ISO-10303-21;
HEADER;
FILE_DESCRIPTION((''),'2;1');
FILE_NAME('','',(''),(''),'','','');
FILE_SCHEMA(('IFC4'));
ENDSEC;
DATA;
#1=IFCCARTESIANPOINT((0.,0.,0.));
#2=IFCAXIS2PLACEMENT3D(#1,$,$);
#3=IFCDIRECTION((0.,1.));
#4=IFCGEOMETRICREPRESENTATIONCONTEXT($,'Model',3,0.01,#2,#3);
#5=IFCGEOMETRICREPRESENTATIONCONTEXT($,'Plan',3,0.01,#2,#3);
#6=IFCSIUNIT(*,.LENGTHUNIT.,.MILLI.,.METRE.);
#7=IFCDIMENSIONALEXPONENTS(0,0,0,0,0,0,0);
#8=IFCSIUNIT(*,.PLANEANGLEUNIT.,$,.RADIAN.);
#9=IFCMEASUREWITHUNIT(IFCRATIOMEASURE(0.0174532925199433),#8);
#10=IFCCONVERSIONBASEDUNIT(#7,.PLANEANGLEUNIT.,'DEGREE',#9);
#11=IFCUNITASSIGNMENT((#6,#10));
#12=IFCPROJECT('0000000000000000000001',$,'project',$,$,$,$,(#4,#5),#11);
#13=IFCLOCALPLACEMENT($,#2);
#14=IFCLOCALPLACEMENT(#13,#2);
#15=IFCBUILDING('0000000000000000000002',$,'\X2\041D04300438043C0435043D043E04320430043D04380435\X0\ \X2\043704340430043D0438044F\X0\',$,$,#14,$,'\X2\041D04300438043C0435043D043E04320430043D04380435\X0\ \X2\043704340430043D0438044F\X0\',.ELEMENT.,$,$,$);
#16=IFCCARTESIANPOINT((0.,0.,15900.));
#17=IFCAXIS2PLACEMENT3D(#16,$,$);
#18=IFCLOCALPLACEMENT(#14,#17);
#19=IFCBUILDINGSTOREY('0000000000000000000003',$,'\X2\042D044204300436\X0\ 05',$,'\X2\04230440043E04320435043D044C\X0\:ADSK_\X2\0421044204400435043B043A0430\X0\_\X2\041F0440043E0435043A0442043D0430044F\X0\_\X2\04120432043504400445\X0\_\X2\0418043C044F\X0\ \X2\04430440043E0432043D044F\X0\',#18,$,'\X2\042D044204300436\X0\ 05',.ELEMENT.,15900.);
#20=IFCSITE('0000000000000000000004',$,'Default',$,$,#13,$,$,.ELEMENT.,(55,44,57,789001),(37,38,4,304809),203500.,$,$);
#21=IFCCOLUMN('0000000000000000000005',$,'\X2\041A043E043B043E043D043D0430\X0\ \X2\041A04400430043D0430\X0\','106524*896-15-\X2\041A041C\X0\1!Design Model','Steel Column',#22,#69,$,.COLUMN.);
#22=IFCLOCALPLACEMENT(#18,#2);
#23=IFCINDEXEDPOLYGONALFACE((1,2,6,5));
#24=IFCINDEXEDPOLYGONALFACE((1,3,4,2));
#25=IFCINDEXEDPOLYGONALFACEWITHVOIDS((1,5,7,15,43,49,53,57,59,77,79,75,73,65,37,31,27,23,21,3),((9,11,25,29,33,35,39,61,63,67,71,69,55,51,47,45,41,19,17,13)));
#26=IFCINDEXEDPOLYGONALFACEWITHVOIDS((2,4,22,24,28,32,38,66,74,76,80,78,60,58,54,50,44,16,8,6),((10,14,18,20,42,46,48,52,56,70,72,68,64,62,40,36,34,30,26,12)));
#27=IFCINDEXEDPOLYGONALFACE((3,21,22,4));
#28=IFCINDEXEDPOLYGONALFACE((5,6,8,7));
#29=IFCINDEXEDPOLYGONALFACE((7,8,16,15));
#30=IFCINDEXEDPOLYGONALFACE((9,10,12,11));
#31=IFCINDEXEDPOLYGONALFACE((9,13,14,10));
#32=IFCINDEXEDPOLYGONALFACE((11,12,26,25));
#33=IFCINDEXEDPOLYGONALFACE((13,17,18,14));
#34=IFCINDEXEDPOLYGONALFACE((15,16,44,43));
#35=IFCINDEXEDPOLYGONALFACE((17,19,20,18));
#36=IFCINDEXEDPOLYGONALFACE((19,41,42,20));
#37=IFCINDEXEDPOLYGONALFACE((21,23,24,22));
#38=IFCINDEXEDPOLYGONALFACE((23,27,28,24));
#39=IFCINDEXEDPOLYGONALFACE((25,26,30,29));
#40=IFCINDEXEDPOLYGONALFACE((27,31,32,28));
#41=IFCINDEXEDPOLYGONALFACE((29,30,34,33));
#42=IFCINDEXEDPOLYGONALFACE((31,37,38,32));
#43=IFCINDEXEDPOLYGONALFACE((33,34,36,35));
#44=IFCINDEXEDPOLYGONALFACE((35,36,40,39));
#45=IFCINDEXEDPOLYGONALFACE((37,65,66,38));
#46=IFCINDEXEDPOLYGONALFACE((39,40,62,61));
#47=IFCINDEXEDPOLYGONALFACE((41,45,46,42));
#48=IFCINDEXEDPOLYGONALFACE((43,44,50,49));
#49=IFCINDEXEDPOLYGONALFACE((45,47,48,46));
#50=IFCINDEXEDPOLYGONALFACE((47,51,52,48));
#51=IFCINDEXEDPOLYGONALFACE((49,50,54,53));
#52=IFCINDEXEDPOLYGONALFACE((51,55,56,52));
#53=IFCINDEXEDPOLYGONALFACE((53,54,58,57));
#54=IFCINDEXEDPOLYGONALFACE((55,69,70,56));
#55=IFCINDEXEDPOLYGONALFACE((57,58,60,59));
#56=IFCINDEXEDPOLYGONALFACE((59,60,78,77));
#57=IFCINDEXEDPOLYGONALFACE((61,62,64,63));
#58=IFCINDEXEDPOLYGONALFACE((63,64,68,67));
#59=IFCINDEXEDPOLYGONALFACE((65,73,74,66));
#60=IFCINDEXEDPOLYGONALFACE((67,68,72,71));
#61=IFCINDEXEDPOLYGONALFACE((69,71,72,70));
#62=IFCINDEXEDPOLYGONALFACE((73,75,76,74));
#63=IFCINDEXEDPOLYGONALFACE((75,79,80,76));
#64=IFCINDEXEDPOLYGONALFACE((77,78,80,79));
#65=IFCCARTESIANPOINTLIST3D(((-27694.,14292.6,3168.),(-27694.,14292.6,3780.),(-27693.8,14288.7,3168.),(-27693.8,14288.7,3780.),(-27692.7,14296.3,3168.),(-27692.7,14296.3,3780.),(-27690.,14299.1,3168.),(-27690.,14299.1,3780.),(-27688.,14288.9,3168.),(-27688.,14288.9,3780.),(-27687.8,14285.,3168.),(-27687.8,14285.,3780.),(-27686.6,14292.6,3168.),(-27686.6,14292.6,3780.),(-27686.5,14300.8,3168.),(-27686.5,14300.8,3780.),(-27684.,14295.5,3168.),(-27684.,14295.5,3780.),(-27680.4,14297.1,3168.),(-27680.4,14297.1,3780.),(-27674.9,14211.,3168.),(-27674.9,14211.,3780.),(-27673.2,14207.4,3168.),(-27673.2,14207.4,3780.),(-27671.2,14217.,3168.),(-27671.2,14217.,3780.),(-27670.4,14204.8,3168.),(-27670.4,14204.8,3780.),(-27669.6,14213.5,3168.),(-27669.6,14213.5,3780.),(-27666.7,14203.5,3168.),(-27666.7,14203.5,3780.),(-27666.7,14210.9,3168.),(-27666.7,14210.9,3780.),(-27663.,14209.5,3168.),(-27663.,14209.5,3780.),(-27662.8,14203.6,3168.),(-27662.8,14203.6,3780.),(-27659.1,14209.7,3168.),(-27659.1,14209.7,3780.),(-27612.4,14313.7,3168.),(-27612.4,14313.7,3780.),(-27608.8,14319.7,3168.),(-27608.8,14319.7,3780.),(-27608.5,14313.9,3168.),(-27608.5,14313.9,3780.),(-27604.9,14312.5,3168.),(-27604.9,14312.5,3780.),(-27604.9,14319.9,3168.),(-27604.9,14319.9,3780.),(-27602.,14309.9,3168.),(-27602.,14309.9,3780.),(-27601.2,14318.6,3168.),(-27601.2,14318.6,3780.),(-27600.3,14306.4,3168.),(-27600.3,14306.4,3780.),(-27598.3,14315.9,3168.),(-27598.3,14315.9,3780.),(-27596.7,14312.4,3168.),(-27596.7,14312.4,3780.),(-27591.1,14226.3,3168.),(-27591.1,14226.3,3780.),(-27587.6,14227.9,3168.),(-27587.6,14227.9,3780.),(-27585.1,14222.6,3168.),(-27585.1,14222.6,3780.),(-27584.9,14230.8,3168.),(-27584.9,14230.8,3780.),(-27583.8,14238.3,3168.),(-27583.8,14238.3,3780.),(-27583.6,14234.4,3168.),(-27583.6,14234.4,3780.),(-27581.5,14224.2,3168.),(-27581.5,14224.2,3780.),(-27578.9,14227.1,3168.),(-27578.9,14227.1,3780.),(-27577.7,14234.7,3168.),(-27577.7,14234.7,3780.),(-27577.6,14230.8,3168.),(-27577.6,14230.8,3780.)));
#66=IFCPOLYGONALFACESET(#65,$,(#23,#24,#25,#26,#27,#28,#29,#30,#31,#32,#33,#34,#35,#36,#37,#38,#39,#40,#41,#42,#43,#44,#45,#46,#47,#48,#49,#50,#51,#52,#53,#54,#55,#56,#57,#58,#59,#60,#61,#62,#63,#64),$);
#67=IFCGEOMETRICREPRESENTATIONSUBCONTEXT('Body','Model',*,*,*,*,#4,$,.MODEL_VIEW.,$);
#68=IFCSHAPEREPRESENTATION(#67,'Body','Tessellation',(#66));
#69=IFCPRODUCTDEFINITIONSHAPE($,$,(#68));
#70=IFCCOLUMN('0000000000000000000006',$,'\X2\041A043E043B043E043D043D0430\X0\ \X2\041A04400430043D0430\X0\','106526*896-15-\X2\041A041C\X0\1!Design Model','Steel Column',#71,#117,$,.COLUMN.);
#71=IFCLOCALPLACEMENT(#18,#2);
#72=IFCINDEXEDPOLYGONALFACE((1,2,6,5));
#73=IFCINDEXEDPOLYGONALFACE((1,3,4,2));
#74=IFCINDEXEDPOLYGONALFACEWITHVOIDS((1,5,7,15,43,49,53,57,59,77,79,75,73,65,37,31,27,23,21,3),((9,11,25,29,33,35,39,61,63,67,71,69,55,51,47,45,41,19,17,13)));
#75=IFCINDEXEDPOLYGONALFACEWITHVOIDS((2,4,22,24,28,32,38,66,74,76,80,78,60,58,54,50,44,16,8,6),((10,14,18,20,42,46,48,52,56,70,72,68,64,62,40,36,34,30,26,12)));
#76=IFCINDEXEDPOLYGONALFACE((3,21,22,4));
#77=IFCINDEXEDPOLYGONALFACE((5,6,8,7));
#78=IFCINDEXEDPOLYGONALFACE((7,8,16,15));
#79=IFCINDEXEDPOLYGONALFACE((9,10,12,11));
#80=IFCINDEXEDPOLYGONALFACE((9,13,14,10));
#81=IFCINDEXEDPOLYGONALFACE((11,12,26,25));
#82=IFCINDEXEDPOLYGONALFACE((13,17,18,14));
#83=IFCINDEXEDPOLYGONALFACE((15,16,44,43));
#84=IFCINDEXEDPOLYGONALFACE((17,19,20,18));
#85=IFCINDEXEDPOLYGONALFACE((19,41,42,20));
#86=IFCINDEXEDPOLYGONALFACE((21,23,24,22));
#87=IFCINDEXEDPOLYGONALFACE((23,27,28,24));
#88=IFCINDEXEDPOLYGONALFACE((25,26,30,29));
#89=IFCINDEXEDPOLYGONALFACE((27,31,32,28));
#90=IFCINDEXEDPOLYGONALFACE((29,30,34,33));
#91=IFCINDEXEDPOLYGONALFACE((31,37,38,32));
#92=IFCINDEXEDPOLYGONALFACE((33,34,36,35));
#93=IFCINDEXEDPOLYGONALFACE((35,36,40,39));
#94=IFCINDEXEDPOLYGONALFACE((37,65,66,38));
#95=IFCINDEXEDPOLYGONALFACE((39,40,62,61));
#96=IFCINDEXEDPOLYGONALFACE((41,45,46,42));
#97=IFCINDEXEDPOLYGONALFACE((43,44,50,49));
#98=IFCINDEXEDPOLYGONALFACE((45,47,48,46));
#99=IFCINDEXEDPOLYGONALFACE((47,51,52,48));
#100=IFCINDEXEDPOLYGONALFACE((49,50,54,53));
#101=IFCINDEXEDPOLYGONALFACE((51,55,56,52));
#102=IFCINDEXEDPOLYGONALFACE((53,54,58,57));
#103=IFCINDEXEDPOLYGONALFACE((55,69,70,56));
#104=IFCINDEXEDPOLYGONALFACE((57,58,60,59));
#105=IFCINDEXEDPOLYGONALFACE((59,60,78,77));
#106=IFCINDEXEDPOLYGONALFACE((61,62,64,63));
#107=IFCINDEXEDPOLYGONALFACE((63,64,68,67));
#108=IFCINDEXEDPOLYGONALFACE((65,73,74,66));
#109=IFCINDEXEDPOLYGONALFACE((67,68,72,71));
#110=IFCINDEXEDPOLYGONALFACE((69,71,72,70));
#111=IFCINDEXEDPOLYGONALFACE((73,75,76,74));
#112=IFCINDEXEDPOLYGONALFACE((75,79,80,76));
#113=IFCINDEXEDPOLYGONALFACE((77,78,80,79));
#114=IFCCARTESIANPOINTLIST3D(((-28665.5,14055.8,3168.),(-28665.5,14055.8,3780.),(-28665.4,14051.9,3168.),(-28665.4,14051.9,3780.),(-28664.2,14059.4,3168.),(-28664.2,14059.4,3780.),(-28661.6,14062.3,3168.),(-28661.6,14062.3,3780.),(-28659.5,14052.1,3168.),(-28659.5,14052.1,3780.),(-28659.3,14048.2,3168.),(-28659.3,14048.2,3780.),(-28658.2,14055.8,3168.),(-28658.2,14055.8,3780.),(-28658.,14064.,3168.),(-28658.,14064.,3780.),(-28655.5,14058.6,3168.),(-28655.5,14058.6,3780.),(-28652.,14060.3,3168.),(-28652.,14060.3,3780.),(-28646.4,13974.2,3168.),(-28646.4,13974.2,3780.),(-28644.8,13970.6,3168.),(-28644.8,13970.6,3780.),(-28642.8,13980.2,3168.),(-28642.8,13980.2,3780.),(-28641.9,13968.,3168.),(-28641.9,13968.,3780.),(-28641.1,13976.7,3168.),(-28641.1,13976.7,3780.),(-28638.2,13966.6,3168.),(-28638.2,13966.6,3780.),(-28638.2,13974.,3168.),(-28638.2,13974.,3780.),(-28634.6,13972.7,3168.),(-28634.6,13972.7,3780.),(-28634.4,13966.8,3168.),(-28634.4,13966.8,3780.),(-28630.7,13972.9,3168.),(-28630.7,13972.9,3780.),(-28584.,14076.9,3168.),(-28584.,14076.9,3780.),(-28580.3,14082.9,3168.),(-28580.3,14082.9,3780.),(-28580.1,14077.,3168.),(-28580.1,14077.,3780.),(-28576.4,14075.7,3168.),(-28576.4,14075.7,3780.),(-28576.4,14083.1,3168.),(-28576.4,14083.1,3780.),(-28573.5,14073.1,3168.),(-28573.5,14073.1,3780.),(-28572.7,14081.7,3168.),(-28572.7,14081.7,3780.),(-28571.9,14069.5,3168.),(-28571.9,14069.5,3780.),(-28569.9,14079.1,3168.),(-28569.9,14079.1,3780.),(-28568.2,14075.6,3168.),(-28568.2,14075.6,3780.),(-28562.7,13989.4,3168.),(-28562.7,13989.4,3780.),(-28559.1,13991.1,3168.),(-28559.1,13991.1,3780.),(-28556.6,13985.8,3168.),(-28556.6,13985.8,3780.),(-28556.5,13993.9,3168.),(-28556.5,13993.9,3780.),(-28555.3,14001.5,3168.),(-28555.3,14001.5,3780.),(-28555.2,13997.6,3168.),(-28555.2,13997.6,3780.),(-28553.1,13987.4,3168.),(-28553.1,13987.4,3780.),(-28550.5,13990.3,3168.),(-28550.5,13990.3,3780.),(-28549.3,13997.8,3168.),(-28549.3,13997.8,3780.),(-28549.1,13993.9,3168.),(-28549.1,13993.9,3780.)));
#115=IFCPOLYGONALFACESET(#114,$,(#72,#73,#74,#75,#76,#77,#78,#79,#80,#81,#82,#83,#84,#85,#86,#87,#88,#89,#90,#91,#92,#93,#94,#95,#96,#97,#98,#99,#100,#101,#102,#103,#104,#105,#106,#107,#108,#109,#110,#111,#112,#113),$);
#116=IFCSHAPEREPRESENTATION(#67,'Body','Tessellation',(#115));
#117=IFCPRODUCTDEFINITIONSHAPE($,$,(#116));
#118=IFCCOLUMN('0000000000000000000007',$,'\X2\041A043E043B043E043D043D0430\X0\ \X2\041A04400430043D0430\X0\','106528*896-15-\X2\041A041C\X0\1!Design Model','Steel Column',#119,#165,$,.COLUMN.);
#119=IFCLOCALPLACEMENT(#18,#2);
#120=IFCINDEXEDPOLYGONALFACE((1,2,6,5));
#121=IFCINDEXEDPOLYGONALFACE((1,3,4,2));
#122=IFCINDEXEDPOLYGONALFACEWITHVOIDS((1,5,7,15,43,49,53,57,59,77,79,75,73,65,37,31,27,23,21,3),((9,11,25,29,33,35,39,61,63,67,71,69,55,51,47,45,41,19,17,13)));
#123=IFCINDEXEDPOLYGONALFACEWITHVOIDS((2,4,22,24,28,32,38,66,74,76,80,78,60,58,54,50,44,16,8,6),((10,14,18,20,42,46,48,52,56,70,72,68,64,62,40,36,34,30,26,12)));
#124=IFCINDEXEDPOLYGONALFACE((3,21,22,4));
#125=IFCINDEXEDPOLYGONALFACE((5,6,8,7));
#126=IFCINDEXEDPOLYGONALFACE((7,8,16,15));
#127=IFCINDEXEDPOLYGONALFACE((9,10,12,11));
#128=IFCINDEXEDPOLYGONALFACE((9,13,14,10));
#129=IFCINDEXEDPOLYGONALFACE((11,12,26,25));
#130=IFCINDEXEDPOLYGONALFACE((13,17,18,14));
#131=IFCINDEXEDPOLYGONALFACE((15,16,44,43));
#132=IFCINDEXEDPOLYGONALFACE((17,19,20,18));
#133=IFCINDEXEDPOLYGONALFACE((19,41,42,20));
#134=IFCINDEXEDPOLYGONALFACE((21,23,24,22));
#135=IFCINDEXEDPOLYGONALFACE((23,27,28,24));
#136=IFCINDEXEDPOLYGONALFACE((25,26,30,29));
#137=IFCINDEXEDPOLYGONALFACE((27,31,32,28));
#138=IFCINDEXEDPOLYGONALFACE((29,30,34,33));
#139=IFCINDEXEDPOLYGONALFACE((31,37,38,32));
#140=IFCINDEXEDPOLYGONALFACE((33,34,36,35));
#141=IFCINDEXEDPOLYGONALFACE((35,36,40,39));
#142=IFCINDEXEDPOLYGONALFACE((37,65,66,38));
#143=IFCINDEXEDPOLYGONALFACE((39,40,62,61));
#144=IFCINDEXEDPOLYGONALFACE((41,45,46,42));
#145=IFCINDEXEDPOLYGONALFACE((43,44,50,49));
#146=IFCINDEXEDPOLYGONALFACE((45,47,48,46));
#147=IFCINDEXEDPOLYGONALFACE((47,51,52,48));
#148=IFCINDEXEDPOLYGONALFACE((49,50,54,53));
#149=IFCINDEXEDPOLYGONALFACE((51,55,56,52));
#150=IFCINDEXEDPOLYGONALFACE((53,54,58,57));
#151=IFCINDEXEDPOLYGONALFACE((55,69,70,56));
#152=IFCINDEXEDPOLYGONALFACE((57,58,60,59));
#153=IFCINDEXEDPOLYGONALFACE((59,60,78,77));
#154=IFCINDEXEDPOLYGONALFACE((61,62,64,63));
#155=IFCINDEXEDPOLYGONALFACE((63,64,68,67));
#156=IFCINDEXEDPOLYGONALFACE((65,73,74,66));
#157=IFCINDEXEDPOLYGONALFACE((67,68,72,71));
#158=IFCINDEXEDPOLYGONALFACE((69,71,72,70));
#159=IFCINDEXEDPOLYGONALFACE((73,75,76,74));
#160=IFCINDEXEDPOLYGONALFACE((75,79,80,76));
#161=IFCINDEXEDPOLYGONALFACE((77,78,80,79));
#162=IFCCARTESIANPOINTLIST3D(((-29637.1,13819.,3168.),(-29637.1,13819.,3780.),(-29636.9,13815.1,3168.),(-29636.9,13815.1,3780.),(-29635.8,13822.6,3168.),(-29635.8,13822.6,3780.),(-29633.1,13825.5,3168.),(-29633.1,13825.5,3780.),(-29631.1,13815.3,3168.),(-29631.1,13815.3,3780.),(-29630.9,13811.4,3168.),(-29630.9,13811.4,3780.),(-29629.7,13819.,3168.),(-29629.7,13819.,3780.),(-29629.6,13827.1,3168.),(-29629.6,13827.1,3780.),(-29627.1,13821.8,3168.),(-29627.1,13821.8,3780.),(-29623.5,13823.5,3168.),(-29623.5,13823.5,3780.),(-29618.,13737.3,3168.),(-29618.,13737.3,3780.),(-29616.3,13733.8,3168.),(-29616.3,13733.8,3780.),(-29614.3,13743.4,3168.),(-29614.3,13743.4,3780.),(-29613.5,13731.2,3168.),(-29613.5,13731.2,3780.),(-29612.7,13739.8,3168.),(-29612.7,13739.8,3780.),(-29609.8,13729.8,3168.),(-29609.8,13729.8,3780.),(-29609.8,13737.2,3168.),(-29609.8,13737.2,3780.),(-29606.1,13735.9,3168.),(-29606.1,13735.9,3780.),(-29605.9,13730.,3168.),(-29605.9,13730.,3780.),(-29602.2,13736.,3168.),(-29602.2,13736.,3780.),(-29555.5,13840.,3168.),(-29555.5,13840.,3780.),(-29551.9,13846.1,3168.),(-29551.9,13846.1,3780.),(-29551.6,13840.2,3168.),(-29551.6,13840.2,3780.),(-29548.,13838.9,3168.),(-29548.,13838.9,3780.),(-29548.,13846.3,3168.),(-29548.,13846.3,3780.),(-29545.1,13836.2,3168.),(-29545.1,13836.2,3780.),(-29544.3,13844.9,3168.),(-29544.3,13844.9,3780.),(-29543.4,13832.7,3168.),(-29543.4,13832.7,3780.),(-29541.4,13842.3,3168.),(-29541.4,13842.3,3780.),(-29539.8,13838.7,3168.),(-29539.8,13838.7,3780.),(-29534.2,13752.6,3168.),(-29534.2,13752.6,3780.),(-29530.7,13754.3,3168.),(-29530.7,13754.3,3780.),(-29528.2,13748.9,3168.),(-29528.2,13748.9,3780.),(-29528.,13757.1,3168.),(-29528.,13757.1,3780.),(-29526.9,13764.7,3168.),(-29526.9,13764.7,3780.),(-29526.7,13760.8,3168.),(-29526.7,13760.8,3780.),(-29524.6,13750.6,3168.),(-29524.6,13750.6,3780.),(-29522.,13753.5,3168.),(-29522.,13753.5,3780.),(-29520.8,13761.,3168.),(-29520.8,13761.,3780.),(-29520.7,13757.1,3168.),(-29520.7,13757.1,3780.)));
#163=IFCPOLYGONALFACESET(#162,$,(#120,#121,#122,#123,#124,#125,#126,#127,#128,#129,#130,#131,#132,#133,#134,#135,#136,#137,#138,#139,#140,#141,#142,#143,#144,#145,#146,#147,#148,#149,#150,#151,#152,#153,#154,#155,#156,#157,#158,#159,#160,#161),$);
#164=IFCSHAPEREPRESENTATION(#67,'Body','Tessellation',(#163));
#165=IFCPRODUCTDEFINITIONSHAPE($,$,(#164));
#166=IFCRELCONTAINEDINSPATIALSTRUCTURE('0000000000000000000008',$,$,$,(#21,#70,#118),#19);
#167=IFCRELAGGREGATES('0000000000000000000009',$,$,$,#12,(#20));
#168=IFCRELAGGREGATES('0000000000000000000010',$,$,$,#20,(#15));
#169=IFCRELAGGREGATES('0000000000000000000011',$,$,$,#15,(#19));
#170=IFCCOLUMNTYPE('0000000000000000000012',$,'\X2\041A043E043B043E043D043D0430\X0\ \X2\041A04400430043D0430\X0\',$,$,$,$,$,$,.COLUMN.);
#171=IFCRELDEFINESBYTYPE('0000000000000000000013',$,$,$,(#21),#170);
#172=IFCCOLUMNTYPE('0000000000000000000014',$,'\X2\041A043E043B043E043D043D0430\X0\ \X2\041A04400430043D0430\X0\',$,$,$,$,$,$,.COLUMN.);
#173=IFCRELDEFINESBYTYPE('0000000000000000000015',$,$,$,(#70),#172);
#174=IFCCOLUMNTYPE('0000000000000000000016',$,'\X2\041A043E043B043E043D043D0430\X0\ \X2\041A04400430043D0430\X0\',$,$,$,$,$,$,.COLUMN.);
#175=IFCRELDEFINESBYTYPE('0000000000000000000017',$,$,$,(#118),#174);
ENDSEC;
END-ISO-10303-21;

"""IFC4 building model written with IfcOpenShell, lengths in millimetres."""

from ifc_helpers import new_model, entity, si_unit, converted_unit, direction, frame, origin, place, context, subcontext, project, spatial, indexed_curve, outline, extrude, type_object, element, save


model = new_model("IFC4")

# Units and contexts
model_context = context("Model", 3, precision=0.01, world=origin(), true_north=direction((0.0, 1.0)))
plan_context = context("Plan", 3, precision=0.01, world=origin(), true_north=direction((0.0, 1.0)))
body_context = subcontext(model_context, "Body", "Model", "MODEL_VIEW")
ifc_project = project(units=[si_unit("LENGTHUNIT", "METRE", prefix="MILLI"), converted_unit("PLANEANGLEUNIT", "DEGREE", entity("IfcRatioMeasure", 0.0174532925199433), si_unit("PLANEANGLEUNIT", "RADIAN"), dimensions=[0, 0, 0, 0, 0, 0, 0])], contexts=[model_context, plan_context])

# Site, building, storey
site_placement = place(None, origin())
site = spatial("IfcSite", under=ifc_project, at=site_placement, Name="Default", CompositionType="ELEMENT", RefLatitude=(55, 44, 57, 789001), RefLongitude=(37, 38, 4, 304809), RefElevation=203500.0)
building_placement = place(site_placement, origin())
building = spatial("IfcBuilding", under=site, at=building_placement, Name="Наименование здания", LongName="Наименование здания", CompositionType="ELEMENT")
storey_placement = place(building_placement, frame((0.0, 0.0, 15900.0)))
storey = spatial("IfcBuildingStorey", under=building, at=storey_placement, Name="Этаж 05", ObjectType="Уровень:ADSK_Стрелка_Проектная_Вверх_Имя уровня", LongName="Этаж 05", CompositionType="ELEMENT", Elevation=15900.0)

# Columns
placement = place(storey_placement, origin())
column_type_1 = type_object("IfcColumnType", Name="Колонна Крана", PredefinedType="COLUMN")
element("IfcColumn", 1, at=placement, inside=storey, type_object=column_type_1, Name="Колонна Крана", Description="106524*896-15-КМ1!Design Model", ObjectType="Steel Column", PredefinedType="COLUMN", context=body_context, shape_type="SweptSolid", body=[
    extrude(outline(indexed_curve([(29.5, -56.8), (33.4, -56.8), (37.0, -55.3), (39.7, -52.6), (41.2, -49.0), (56.8, 29.5), (56.8, 33.4), (55.3, 37.0), (52.6, 39.7), (49.0, 41.2), (-29.5, 56.8), (-33.4, 56.8), (-37.0, 55.3), (-39.7, 52.6), (-41.2, 49.0), (-56.8, -29.5), (-56.8, -33.4), (-55.3, -37.0), (-52.6, -39.7), (-49.0, -41.2), (29.5, -56.8)], self_intersect=False), holes=[indexed_curve([(-43.1, -37.3), (-46.7, -35.8), (-49.5, -33.1), (-51.0, -29.5), (-51.0, -25.5), (-37.3, 43.1), (-35.8, 46.7), (-33.1, 49.5), (-29.5, 51.0), (-25.5, 51.0), (43.1, 37.3), (46.7, 35.8), (49.5, 33.1), (51.0, 29.5), (51.0, 25.5), (37.3, -43.1), (35.8, -46.7), (33.1, -49.5), (29.5, -51.0), (25.5, -51.0), (-43.1, -37.3)], self_intersect=False)]), frame((-27635.8, 14261.7, 3168.0), z_axis=(0.0, 0.0, 1.0), x_axis=(0.906681, 0.421816, 0.0)), (0.0, 0.0, 1.0), 612.0),
])
column_type_2 = type_object("IfcColumnType", Name="Колонна Крана", PredefinedType="COLUMN")
element("IfcColumn", 2, at=placement, inside=storey, type_object=column_type_2, Name="Колонна Крана", Description="106526*896-15-КМ1!Design Model", ObjectType="Steel Column", PredefinedType="COLUMN", context=body_context, shape_type="SweptSolid", body=[
    extrude(outline(indexed_curve([(29.5, -56.8), (33.4, -56.8), (37.0, -55.3), (39.7, -52.6), (41.2, -49.0), (56.8, 29.5), (56.8, 33.4), (55.3, 37.0), (52.6, 39.7), (49.0, 41.2), (-29.5, 56.8), (-33.4, 56.8), (-37.0, 55.3), (-39.7, 52.6), (-41.2, 49.0), (-56.8, -29.5), (-56.8, -33.4), (-55.3, -37.0), (-52.6, -39.7), (-49.0, -41.2), (29.5, -56.8)], self_intersect=False), holes=[indexed_curve([(-43.1, -37.3), (-46.7, -35.8), (-49.5, -33.1), (-51.0, -29.5), (-51.0, -25.5), (-37.3, 43.1), (-35.8, 46.7), (-33.1, 49.5), (-29.5, 51.0), (-25.5, 51.0), (43.1, 37.3), (46.7, 35.8), (49.5, 33.1), (51.0, 29.5), (51.0, 25.5), (37.3, -43.1), (35.8, -46.7), (33.1, -49.5), (29.5, -51.0), (25.5, -51.0), (-43.1, -37.3)], self_intersect=False)]), frame((-28607.3, 14024.9, 3168.0), z_axis=(0.0, 0.0, 1.0), x_axis=(0.906681, 0.421816, 0.0)), (0.0, 0.0, 1.0), 612.0),
])
column_type_3 = type_object("IfcColumnType", Name="Колонна Крана", PredefinedType="COLUMN")
element("IfcColumn", 3, at=placement, inside=storey, type_object=column_type_3, Name="Колонна Крана", Description="106528*896-15-КМ1!Design Model", ObjectType="Steel Column", PredefinedType="COLUMN", context=body_context, shape_type="SweptSolid", body=[
    extrude(outline(indexed_curve([(29.5, -56.8), (33.4, -56.8), (37.0, -55.3), (39.7, -52.6), (41.2, -49.0), (56.8, 29.5), (56.8, 33.4), (55.3, 37.0), (52.6, 39.7), (49.0, 41.2), (-29.5, 56.8), (-33.4, 56.8), (-37.0, 55.3), (-39.7, 52.6), (-41.2, 49.0), (-56.8, -29.5), (-56.8, -33.4), (-55.3, -37.0), (-52.6, -39.7), (-49.0, -41.2), (29.5, -56.8)], self_intersect=False), holes=[indexed_curve([(-43.1, -37.3), (-46.7, -35.8), (-49.5, -33.1), (-51.0, -29.5), (-51.0, -25.5), (-37.3, 43.1), (-35.8, 46.7), (-33.1, 49.5), (-29.5, 51.0), (-25.5, 51.0), (43.1, 37.3), (46.7, 35.8), (49.5, 33.1), (51.0, 29.5), (51.0, 25.5), (37.3, -43.1), (35.8, -46.7), (33.1, -49.5), (29.5, -51.0), (25.5, -51.0), (-43.1, -37.3)], self_intersect=False)]), frame((-29578.9, 13788.0, 3168.0), z_axis=(0.0, 0.0, 1.0), x_axis=(0.906681, 0.421816, 0.0)), (0.0, 0.0, 1.0), 612.0),
])

save(model, "model.ifc")
